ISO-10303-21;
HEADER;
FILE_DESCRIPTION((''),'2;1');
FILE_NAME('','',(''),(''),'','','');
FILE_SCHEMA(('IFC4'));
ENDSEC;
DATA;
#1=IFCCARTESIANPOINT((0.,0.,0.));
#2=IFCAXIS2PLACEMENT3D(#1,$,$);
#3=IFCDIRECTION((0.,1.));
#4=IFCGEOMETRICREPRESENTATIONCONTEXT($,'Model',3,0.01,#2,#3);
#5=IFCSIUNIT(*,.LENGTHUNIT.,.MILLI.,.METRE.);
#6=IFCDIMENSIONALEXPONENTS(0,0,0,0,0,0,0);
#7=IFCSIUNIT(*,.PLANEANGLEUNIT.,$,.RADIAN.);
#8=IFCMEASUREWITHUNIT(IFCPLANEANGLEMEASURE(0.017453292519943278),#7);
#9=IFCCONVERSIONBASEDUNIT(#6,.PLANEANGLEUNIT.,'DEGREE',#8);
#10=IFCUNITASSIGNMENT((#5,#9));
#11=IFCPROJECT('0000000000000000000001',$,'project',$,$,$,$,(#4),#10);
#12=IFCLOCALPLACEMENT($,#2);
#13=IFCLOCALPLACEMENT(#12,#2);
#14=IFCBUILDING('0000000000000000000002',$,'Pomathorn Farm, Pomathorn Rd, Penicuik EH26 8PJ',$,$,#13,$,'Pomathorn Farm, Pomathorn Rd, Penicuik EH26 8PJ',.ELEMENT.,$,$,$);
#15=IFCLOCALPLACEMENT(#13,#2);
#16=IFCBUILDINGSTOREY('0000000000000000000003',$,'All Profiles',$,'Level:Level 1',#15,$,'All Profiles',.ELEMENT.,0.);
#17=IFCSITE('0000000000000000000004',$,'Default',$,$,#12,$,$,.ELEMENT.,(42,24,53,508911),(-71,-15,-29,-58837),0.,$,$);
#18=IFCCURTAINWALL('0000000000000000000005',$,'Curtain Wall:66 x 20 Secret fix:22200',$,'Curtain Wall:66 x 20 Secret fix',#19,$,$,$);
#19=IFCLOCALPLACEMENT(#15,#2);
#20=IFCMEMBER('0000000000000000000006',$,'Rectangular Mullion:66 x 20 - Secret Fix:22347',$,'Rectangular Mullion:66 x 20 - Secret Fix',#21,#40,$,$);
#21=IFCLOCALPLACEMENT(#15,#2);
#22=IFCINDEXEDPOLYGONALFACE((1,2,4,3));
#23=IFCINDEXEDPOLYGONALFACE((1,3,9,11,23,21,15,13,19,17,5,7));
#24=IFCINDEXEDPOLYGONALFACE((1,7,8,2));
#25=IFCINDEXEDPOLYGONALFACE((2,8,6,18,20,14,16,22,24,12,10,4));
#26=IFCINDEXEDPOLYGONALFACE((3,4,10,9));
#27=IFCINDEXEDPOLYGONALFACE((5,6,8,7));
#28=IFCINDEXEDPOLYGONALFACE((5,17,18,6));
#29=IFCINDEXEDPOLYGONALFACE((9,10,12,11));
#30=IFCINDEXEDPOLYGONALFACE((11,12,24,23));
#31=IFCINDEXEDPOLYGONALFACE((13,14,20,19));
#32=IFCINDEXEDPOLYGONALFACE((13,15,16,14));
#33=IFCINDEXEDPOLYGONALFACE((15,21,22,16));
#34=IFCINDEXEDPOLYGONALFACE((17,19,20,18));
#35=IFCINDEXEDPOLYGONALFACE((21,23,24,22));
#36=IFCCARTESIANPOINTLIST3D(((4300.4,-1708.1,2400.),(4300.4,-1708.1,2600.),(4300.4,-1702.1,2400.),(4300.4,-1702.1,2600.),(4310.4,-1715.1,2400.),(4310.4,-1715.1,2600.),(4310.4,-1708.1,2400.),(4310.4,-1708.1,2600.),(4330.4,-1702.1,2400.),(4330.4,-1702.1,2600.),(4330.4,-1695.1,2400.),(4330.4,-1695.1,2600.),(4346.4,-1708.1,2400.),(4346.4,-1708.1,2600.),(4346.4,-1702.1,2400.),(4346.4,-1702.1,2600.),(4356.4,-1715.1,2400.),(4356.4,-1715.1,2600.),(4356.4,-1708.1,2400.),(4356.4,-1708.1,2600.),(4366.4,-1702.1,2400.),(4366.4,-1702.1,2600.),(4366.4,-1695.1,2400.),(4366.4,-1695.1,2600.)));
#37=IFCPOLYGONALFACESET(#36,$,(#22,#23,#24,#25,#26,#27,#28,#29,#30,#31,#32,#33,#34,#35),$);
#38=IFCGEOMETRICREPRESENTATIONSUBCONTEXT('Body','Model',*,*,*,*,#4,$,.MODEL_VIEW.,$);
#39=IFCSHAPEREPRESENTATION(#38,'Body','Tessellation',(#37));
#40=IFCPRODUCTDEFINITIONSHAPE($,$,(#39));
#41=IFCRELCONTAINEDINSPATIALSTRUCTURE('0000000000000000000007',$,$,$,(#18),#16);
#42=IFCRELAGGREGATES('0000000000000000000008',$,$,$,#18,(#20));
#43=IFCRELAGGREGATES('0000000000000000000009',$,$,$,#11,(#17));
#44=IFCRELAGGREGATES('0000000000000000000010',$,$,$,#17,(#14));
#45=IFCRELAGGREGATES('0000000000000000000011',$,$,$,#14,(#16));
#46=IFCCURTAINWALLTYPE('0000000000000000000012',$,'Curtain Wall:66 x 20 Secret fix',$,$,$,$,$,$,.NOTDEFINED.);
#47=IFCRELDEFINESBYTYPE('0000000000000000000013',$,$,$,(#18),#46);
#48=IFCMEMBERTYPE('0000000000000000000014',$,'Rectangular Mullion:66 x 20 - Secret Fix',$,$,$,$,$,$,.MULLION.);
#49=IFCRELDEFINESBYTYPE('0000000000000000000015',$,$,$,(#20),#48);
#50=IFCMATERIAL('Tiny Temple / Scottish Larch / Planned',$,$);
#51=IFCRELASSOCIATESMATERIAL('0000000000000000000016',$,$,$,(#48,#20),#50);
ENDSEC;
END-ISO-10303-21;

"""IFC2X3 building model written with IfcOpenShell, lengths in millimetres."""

from ifc_helpers import new_model, entity, si_unit, converted_unit, direction, frame, origin, place, context, subcontext, project, spatial, polyline, outline, extrude, source, transform, mapped, material, type_object, type_shapes, element, aggregate, save


model = new_model("IFC2X3")

# Units and contexts
model_context = context("Model", 3, precision=0.01, world=origin(), true_north=direction((0.0, 1.0)))
body_context = subcontext(model_context, "Body", "Model", "MODEL_VIEW")
ifc_project = project(units=[si_unit("LENGTHUNIT", "METRE", prefix="MILLI"), converted_unit("PLANEANGLEUNIT", "DEGREE", entity("IfcPlaneAngleMeasure", 0.017453292519943278), si_unit("PLANEANGLEUNIT", "RADIAN"), dimensions=[0, 0, 0, 0, 0, 0, 0])], contexts=[model_context])

# Site, building, storey
site_placement = place(None, origin())
site = spatial("IfcSite", under=ifc_project, at=site_placement, Name="Default", CompositionType="ELEMENT", RefLatitude=(42, 24, 53, 508911), RefLongitude=(-71, -15, -29, -58837), RefElevation=0.0)
building_placement = place(site_placement, origin())
building = spatial("IfcBuilding", under=site, at=building_placement, Name="Pomathorn Farm, Pomathorn Rd, Penicuik EH26 8PJ", LongName="Pomathorn Farm, Pomathorn Rd, Penicuik EH26 8PJ", CompositionType="ELEMENT")
storey_placement = place(building_placement, origin())
storey = spatial("IfcBuildingStorey", under=building, at=storey_placement, Name="All Profiles", ObjectType="Level:Level 1", LongName="All Profiles", CompositionType="ELEMENT", Elevation=0.0)

# Curtain wall, member
curtain_wall_type = type_object("IfcCurtainWallType", Name="Curtain Wall:66 x 20 Secret fix", PredefinedType="NOTDEFINED")
curtain_wall_placement = place(storey_placement, origin())
curtain_wall = element("IfcCurtainWall", 1, at=curtain_wall_placement, inside=storey, type_object=curtain_wall_type, Name="Curtain Wall:66 x 20 Secret fix:22200", ObjectType="Curtain Wall:66 x 20 Secret fix")
ifc_material = material(Name="Tiny Temple / Scottish Larch / Planned")
member_type_1 = type_object("IfcMemberType", Name="Rectangular Mullion:66 x 20 - Secret Fix", PredefinedType="MULLION", material=ifc_material)
shared_shape_1 = source(origin(), body_context, "Body", "SweptSolid", [
    extrude(outline(polyline([(-3.0, -34.7), (3.0, -34.7), (3.0, -4.7), (10.0, -4.7), (10.0, 31.3), (3.0, 31.3), (3.0, 11.3), (-3.0, 11.3), (-3.0, 21.3), (-10.0, 21.3), (-10.0, -24.7), (-3.0, -24.7), (-3.0, -34.7)])), frame((-31.3, -10.0, -200.0), z_axis=(0.0, 0.0, 1.0), x_axis=(0.0, -1.0, 0.0)), (0.0, 0.0, 1.0), 200.0),
])
type_shapes(member_type_1, [shared_shape_1])
member_1_placement = place(curtain_wall_placement, frame((4366.4, -1715.1, 2400.0), z_axis=(0.0, 0.0, -1.0), x_axis=(1.0, 0.0, 0.0)))
member_1 = element("IfcMember", 2, at=member_1_placement, type_object=member_type_1, material=ifc_material, Name="Rectangular Mullion:66 x 20 - Secret Fix:22347", ObjectType="Rectangular Mullion:66 x 20 - Secret Fix", context=body_context, shape_type="MappedRepresentation", body=[
    mapped(shared_shape_1, transform((0.0, 0.0, 0.0), scale=1.0)),
])
aggregate(curtain_wall, [member_1])

save(model, "model.ifc")
